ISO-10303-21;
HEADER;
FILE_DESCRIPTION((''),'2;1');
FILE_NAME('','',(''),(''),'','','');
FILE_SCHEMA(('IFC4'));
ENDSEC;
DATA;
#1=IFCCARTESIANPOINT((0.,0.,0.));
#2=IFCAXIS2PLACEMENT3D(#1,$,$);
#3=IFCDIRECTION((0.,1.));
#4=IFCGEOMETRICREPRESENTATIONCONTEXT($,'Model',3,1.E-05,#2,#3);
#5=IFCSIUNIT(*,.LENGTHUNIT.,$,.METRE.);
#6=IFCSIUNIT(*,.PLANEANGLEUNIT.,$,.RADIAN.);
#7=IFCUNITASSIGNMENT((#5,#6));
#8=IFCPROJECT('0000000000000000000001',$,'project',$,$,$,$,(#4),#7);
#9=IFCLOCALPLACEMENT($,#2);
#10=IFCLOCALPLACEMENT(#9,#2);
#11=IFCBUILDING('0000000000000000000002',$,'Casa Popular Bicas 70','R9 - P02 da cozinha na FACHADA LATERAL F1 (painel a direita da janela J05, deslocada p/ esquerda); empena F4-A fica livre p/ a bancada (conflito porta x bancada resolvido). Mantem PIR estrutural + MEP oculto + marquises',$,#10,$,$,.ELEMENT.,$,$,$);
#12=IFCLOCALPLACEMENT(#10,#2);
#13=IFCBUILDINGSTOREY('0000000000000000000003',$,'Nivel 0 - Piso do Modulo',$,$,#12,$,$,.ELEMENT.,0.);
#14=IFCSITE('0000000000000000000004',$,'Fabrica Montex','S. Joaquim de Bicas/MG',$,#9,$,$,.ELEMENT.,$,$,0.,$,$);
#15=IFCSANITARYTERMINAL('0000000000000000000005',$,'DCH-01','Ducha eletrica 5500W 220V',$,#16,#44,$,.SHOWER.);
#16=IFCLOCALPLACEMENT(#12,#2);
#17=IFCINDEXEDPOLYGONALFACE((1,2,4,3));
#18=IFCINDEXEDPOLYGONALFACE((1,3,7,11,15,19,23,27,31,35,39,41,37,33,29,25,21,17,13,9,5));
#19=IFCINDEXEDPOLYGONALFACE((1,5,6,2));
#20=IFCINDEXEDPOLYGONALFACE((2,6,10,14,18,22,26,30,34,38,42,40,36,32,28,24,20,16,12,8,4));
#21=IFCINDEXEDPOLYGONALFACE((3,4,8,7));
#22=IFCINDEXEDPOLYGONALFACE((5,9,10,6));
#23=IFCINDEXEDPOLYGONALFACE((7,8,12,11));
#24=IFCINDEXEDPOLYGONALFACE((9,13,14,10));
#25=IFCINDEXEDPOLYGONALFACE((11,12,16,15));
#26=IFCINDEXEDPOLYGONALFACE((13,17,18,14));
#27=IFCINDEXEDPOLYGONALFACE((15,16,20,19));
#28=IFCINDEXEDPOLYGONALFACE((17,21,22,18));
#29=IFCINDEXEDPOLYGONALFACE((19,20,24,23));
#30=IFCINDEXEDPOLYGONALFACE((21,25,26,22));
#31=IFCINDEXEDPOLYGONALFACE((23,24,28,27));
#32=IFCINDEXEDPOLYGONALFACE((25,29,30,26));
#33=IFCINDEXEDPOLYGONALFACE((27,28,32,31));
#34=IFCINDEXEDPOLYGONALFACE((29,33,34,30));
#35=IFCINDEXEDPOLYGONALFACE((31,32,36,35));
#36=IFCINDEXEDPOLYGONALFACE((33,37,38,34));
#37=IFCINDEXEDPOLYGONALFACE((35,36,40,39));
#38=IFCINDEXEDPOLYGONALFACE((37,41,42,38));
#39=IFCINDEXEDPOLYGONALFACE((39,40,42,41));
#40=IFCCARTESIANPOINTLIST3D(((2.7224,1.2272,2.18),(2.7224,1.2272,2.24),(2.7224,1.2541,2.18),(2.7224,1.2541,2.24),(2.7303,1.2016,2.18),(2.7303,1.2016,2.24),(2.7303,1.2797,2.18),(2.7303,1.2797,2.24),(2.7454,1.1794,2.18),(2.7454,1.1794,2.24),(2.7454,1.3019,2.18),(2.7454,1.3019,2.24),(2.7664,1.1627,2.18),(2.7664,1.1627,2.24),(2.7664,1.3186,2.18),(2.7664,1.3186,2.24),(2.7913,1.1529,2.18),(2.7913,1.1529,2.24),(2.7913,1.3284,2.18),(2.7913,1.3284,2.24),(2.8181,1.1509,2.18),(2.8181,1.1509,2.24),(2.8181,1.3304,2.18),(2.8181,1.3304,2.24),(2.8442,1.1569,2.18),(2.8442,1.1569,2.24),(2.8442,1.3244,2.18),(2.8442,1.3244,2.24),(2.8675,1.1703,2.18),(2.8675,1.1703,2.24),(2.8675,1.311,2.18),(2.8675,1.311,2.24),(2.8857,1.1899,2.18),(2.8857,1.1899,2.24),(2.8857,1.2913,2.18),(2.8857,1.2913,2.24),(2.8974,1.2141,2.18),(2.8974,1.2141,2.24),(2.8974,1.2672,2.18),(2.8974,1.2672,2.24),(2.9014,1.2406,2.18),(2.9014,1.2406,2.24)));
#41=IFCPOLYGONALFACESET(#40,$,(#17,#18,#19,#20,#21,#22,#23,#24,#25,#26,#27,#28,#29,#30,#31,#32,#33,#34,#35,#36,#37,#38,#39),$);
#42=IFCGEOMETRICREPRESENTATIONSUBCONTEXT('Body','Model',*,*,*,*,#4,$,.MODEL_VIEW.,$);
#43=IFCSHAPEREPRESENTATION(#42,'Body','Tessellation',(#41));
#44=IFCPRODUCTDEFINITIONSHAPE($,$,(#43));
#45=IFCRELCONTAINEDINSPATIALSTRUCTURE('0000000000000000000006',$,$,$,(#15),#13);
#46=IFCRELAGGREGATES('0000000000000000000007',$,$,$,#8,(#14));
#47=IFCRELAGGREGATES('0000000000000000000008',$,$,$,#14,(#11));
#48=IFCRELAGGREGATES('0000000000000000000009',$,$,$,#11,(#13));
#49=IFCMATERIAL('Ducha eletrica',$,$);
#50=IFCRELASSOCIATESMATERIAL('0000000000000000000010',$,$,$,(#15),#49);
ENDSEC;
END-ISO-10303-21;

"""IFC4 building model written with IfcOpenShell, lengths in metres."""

from ifc_helpers import new_model, si_unit, direction, frame, origin, origin_2d, place, context, subcontext, project, spatial, circle, extrude, material, element, save


model = new_model("IFC4")

# Units and contexts
model_context = context("Model", 3, precision=1e-05, world=origin(), true_north=direction((0.0, 1.0)))
body_context = subcontext(model_context, "Body", "Model", "MODEL_VIEW")
ifc_project = project(units=[si_unit("LENGTHUNIT", "METRE"), si_unit("PLANEANGLEUNIT", "RADIAN")], contexts=[model_context])

# Site, building, storey
site_placement = place(None, origin())
site = spatial("IfcSite", under=ifc_project, at=site_placement, Name="Fabrica Montex", Description="S. Joaquim de Bicas/MG", CompositionType="ELEMENT", RefElevation=0.0)
building_placement = place(site_placement, origin())
building = spatial("IfcBuilding", under=site, at=building_placement, Name="Casa Popular Bicas 70", Description="R9 - P02 da cozinha na FACHADA LATERAL F1 (painel a direita da janela J05, deslocada p/ esquerda); empena F4-A fica livre p/ a bancada (conflito porta x bancada resolvido). Mantem PIR estrutural + MEP oculto + marquises", CompositionType="ELEMENT")
storey_placement = place(building_placement, origin())
storey = spatial("IfcBuildingStorey", under=building, at=storey_placement, Name="Nivel 0 - Piso do Modulo", CompositionType="ELEMENT", Elevation=0.0)

# Sanitary terminal
ifc_material_1 = material(Name="Ducha eletrica")
sanitary_terminal_placement = place(storey_placement, frame((2.8114, 1.2406, 2.18)))
element("IfcSanitaryTerminal", 1, at=sanitary_terminal_placement, inside=storey, material=ifc_material_1, Name="DCH-01", Description="Ducha eletrica 5500W 220V", PredefinedType="SHOWER", context=body_context, shape_type="SweptSolid", body=[
    extrude(circle(Radius=0.09, at=origin_2d()), origin(), (0.0, 0.0, 1.0), 0.06),
])

save(model, "model.ifc")
